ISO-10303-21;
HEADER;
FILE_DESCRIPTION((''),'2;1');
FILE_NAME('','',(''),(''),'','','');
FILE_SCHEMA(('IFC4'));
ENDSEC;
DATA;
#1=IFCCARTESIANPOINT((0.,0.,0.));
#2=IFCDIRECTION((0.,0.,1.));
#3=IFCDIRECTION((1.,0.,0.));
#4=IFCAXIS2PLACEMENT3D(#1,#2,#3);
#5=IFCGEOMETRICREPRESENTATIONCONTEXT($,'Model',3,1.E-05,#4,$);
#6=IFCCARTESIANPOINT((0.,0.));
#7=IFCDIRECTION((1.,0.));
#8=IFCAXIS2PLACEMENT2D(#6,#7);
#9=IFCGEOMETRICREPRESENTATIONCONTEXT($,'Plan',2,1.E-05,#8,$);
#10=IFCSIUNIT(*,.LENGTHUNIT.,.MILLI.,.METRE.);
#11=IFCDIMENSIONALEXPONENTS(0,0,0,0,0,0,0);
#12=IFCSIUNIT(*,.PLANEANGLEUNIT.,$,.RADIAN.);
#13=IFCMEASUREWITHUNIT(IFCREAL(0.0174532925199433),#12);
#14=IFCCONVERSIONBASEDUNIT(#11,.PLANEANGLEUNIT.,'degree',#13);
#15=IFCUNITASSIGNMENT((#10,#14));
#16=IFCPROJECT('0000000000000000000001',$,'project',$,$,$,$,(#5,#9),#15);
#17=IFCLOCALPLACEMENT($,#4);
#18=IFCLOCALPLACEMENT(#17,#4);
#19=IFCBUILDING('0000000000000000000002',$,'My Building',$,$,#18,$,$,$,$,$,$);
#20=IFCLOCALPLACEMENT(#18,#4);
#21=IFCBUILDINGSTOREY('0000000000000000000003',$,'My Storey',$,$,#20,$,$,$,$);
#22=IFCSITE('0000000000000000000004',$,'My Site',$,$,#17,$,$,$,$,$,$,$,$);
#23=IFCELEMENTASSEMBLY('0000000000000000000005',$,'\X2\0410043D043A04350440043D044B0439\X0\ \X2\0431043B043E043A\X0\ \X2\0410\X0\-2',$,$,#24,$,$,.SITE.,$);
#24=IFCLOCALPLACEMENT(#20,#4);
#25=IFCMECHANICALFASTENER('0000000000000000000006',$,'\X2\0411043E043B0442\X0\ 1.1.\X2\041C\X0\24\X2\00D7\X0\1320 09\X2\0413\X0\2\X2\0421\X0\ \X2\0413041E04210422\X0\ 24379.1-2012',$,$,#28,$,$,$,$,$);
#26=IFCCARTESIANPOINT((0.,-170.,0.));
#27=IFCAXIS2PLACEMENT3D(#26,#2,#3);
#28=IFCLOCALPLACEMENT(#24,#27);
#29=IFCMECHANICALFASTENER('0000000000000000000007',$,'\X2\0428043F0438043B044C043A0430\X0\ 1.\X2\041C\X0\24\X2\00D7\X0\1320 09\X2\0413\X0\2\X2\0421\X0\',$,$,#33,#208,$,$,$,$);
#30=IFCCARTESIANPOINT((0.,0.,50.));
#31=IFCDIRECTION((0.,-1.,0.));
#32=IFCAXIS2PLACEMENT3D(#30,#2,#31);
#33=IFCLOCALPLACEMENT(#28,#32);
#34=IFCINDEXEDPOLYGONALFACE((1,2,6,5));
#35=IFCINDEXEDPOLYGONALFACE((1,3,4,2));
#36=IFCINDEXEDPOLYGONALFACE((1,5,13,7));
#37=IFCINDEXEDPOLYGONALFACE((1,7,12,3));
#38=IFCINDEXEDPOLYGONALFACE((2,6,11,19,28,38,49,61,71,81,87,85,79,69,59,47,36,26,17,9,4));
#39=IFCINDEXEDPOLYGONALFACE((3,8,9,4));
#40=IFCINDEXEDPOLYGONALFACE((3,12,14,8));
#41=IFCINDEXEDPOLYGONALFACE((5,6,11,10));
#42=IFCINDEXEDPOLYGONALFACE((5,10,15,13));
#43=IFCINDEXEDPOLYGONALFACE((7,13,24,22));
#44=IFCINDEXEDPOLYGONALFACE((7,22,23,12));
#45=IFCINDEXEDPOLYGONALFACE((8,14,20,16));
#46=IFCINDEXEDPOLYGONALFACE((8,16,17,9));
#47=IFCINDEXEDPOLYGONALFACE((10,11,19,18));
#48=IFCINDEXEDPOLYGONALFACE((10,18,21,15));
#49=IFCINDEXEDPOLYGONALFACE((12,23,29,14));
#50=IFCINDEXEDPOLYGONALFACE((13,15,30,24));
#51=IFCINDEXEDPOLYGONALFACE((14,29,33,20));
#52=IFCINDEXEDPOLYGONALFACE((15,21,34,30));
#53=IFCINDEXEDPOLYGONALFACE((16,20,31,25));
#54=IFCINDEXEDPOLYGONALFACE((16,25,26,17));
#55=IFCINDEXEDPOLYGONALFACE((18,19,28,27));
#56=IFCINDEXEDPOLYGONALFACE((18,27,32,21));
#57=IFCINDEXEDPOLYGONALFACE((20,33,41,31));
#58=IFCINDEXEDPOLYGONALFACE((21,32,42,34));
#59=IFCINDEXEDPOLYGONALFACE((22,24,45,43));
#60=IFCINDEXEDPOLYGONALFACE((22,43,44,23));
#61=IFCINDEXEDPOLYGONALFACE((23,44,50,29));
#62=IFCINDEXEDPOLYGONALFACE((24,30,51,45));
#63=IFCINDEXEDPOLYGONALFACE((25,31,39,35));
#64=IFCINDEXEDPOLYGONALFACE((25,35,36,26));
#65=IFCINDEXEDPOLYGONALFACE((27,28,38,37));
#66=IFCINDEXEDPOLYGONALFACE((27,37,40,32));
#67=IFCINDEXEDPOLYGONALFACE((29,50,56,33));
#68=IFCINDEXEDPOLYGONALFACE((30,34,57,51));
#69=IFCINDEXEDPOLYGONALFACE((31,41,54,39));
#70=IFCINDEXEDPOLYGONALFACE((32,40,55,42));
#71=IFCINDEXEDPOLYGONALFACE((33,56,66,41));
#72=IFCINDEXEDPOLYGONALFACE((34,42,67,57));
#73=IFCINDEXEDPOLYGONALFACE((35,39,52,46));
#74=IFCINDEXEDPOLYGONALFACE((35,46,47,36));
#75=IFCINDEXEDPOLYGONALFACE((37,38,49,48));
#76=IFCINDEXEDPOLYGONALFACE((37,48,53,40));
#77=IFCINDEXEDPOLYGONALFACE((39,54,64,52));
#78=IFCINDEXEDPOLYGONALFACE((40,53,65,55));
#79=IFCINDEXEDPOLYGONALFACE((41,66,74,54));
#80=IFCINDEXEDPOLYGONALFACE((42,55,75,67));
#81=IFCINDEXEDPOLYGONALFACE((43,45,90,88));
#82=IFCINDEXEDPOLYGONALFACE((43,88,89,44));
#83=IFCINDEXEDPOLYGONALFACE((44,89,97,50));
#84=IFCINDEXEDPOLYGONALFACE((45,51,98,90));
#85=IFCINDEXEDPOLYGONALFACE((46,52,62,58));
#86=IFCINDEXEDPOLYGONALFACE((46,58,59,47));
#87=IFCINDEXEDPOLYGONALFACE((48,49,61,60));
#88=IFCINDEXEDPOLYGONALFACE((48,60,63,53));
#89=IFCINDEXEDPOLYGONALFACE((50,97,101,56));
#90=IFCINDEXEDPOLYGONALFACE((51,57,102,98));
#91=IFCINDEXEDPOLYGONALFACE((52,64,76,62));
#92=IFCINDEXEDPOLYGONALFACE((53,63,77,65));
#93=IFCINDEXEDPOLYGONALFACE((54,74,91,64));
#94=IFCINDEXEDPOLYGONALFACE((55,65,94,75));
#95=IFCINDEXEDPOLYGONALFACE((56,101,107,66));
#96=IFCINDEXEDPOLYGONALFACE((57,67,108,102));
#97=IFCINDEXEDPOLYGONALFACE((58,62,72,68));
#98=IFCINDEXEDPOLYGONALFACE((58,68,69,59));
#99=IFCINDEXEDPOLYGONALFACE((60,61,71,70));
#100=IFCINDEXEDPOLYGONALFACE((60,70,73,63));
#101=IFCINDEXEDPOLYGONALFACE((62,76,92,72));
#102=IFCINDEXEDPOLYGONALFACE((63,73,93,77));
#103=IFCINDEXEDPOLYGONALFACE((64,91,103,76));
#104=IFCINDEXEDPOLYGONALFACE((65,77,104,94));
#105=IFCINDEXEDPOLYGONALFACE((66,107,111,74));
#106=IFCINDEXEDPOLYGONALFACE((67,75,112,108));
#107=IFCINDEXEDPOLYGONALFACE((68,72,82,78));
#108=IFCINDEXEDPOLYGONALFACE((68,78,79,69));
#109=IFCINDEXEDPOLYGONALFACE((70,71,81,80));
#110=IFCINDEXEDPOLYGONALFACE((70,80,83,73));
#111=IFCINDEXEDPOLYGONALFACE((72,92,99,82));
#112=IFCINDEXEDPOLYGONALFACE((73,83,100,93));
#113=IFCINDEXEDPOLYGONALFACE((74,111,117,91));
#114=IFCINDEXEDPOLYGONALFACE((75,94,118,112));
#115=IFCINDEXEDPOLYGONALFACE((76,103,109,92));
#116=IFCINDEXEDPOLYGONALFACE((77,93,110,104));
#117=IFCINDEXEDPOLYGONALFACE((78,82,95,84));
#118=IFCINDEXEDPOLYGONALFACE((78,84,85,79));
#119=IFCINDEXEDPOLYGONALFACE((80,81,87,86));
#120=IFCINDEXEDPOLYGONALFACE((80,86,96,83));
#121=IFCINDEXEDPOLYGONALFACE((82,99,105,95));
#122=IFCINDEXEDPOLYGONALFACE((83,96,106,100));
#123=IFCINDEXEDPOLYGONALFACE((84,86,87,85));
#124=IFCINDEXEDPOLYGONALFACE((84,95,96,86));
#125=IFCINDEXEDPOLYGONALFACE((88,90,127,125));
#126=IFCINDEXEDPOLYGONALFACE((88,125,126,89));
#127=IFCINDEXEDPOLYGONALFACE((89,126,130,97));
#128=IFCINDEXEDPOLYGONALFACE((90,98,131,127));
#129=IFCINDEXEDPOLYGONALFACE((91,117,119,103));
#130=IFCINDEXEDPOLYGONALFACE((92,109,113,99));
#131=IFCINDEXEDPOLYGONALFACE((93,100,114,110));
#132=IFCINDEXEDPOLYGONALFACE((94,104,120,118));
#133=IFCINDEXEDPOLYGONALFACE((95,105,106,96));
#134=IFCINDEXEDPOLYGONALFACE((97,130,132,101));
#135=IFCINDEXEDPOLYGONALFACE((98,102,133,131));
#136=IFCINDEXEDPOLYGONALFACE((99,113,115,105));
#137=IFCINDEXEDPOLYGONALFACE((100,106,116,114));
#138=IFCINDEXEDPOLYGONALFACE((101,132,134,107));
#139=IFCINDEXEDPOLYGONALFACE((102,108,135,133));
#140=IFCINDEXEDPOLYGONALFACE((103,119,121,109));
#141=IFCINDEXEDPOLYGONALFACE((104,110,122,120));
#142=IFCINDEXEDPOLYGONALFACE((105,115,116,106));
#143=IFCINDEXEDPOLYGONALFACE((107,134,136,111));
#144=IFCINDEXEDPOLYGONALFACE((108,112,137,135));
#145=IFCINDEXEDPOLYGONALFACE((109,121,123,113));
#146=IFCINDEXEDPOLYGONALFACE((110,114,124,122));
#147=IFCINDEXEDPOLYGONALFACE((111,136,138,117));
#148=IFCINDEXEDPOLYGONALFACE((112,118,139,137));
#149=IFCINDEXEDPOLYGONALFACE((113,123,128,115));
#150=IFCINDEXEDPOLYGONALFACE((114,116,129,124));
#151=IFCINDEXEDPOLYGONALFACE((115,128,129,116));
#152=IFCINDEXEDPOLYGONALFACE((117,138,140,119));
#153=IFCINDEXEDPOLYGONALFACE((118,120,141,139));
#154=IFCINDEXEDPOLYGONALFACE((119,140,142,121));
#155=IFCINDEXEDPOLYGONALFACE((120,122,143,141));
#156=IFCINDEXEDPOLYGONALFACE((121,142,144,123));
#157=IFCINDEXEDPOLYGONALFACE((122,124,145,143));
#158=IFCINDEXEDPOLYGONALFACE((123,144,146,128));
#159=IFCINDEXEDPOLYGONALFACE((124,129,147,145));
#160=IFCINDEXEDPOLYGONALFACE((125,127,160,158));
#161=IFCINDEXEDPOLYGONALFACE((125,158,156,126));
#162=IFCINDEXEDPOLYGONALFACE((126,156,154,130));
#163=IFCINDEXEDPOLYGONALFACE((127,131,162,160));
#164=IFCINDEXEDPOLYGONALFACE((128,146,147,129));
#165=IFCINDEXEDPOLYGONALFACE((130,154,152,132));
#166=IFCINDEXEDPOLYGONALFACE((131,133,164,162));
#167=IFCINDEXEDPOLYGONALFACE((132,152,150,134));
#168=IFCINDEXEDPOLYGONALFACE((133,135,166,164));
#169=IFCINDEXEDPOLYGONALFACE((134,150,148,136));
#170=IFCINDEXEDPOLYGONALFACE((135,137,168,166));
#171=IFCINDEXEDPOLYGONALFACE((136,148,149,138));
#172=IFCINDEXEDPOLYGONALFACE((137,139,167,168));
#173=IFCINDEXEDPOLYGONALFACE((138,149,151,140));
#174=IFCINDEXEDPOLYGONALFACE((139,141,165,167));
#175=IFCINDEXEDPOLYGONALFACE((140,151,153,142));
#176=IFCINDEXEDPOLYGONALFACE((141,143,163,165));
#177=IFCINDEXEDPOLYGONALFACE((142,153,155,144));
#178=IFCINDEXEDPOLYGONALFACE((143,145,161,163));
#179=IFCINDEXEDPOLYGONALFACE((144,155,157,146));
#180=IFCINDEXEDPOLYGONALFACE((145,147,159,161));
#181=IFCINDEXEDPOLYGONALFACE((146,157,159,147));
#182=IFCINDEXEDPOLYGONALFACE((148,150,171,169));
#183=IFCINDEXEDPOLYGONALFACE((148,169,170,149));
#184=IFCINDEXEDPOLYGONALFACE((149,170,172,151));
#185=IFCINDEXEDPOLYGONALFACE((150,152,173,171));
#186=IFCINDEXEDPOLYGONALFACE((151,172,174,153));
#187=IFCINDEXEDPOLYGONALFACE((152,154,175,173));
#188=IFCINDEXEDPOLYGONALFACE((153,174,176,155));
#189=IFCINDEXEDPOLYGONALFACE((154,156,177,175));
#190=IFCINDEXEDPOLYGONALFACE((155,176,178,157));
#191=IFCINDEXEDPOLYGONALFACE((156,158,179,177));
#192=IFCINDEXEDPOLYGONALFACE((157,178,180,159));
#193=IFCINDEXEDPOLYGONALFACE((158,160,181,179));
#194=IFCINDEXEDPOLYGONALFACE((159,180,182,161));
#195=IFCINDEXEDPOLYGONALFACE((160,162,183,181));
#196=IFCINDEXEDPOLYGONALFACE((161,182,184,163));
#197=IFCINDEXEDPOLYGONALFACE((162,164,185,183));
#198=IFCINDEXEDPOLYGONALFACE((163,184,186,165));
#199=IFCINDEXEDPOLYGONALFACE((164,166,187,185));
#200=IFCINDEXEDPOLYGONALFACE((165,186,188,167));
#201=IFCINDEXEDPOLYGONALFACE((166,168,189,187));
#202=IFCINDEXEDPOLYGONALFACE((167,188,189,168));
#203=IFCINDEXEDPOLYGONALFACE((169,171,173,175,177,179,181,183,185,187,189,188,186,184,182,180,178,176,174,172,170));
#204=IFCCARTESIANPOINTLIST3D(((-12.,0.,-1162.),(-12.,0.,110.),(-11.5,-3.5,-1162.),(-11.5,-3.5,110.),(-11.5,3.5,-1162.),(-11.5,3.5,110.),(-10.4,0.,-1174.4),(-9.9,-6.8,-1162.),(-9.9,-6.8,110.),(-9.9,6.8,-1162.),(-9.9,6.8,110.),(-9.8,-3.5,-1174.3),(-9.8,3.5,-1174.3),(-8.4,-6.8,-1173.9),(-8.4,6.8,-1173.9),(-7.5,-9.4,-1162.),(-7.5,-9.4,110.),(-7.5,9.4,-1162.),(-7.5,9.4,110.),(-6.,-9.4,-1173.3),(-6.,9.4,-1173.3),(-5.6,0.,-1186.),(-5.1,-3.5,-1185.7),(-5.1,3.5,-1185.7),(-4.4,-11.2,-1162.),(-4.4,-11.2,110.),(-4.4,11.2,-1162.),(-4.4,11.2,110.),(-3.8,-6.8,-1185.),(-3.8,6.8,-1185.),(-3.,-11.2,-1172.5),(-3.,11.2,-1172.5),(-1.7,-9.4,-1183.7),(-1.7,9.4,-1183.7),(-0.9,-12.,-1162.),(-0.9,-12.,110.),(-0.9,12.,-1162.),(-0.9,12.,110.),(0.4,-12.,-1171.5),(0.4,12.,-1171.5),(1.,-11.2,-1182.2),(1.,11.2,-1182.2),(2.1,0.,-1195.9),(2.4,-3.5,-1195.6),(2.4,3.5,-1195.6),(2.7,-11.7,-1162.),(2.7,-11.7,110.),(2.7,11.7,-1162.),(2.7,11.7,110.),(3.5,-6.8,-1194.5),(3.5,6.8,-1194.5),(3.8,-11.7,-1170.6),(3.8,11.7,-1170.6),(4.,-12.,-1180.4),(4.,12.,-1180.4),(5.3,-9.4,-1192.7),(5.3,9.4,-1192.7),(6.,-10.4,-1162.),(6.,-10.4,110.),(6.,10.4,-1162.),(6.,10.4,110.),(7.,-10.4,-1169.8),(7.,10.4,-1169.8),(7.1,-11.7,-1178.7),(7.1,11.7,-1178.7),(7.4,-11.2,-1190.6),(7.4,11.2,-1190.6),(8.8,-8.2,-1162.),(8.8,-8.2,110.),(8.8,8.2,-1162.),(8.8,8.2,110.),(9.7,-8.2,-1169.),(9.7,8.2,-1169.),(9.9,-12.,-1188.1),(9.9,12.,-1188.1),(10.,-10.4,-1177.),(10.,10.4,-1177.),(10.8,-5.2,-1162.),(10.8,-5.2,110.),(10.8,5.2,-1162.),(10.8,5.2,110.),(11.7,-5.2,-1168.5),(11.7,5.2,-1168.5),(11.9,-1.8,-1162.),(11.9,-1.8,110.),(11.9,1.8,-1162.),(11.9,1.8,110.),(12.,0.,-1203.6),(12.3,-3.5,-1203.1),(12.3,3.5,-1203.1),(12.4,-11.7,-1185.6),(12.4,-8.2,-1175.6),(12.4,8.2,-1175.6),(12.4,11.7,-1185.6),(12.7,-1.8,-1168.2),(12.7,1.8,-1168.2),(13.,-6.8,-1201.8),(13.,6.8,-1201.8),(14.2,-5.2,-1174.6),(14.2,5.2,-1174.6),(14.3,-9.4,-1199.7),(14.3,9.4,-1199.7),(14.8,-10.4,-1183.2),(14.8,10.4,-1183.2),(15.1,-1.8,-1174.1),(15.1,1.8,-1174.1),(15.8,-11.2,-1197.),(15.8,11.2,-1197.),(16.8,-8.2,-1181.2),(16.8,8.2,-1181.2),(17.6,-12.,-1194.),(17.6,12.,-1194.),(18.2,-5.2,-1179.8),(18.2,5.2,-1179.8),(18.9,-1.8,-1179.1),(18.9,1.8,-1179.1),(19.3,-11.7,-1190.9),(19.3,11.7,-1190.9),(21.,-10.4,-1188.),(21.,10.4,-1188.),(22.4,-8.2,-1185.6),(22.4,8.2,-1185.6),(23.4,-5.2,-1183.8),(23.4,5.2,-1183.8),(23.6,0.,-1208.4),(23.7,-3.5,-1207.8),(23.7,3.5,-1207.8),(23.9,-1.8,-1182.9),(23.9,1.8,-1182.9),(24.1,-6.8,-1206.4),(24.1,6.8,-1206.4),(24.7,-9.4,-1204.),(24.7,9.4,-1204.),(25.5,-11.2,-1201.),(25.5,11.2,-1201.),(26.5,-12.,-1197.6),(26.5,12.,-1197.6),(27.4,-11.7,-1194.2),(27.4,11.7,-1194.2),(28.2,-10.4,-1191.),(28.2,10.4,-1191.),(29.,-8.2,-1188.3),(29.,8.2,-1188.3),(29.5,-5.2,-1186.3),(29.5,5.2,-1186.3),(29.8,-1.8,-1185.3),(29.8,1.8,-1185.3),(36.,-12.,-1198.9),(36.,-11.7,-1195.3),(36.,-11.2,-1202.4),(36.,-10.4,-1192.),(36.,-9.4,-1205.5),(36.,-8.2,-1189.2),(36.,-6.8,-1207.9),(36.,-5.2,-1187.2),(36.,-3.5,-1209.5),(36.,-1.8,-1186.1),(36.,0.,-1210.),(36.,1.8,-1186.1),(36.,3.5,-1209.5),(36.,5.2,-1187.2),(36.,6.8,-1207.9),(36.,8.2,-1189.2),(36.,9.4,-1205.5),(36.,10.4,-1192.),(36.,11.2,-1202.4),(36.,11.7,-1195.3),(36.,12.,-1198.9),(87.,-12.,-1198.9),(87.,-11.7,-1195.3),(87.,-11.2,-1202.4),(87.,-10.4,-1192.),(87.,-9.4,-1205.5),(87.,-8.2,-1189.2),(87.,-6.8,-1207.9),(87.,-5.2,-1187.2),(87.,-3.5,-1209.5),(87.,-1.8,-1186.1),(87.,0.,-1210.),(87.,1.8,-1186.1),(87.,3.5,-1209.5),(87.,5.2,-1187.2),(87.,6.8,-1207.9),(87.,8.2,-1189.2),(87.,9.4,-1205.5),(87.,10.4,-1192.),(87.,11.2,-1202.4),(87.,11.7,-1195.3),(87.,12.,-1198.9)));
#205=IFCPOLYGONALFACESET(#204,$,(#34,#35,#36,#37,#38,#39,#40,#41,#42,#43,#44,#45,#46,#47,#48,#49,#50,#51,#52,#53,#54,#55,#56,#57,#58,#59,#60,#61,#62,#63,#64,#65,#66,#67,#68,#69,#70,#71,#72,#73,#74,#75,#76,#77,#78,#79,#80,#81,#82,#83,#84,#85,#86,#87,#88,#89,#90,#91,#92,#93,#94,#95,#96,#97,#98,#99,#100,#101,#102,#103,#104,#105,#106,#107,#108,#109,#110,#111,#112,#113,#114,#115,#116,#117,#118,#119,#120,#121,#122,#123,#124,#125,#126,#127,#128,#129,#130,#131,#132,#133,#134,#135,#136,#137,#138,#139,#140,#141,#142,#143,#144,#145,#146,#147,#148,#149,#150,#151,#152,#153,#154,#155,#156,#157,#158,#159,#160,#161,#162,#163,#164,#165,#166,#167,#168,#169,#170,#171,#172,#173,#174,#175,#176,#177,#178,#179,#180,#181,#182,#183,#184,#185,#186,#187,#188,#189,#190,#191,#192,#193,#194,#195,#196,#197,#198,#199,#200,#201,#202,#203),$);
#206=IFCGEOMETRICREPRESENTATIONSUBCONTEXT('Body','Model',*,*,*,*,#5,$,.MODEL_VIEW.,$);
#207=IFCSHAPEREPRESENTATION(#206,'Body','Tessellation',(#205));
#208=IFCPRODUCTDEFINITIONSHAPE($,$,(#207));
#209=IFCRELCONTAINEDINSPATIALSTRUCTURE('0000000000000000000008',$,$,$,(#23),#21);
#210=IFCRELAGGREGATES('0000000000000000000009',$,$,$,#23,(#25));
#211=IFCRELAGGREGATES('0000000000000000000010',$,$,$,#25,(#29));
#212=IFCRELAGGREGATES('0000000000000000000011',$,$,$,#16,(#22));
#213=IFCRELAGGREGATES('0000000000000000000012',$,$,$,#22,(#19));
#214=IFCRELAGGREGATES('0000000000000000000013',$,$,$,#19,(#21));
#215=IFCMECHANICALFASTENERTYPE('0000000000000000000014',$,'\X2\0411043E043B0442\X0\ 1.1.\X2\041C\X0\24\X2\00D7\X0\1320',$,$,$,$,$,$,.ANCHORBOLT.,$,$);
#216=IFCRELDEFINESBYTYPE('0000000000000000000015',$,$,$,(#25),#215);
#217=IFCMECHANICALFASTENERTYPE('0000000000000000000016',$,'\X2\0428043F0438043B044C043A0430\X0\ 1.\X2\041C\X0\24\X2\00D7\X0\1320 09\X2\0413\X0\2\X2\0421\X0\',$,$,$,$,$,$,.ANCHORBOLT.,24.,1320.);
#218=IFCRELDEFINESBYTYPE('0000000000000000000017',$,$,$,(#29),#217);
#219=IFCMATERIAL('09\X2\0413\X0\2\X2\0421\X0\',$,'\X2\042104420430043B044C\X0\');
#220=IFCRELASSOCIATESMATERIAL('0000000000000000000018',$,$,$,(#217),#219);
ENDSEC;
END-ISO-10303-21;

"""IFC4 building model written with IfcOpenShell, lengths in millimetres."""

from ifc_helpers import new_model, entity, si_unit, converted_unit, frame, origin_with_axes, origin_2d_with_axis, place, context, subcontext, project, spatial, source, transform, mapped, material, type_object, type_shapes, element, aggregate, save


model = new_model("IFC4")

# Units and contexts
model_context = context("Model", 3, precision=1e-05, world=origin_with_axes())
plan_context = context("Plan", 2, precision=1e-05, world=origin_2d_with_axis())
body_context = subcontext(model_context, "Body", "Model", "MODEL_VIEW")
ifc_project = project(units=[si_unit("LENGTHUNIT", "METRE", prefix="MILLI"), converted_unit("PLANEANGLEUNIT", "degree", entity("IfcReal", 0.0174532925199433), si_unit("PLANEANGLEUNIT", "RADIAN"), dimensions=[0, 0, 0, 0, 0, 0, 0])], contexts=[model_context, plan_context])

# Site, building, storey
site_placement = place(None, origin_with_axes())
site = spatial("IfcSite", under=ifc_project, at=site_placement, Name="My Site")
building_placement = place(site_placement, origin_with_axes())
building = spatial("IfcBuilding", under=site, at=building_placement, Name="My Building")
storey_placement = place(building_placement, origin_with_axes())
storey = spatial("IfcBuildingStorey", under=building, at=storey_placement, Name="My Storey")

# Shared definitions
placement = place(storey_placement, origin_with_axes())

# Element assembly, mechanical fasteners
assembly_1 = element("IfcElementAssembly", 1, at=placement, inside=storey, Name="Анкерный блок А-2", AssemblyPlace="SITE")
mechanical_fastener_type_1 = type_object("IfcMechanicalFastenerType", Name="Болт 1.1.М24×1320", PredefinedType="ANCHORBOLT")
mechanical_fastener_1_placement = place(placement, frame((0.0, -170.0, 0.0), z_axis=(0.0, 0.0, 1.0), x_axis=(1.0, 0.0, 0.0)))
mechanical_fastener_1 = element("IfcMechanicalFastener", 2, at=mechanical_fastener_1_placement, type_object=mechanical_fastener_type_1, Name="Болт 1.1.М24×1320 09Г2С ГОСТ 24379.1-2012")
ifc_material_1 = material(Name="09Г2С", Category="Сталь")
mechanical_fastener_type_2 = type_object("IfcMechanicalFastenerType", Name="Шпилька 1.М24×1320 09Г2С", NominalDiameter=24.0, NominalLength=1320.0, PredefinedType="ANCHORBOLT", material=ifc_material_1)
shared_shape_1 = source(frame((0.0, 0.0, 110.0), z_axis=(0.0, 0.0, 1.0), x_axis=(1.0, 0.0, 0.0)), body_context, "Body", "AdvancedSweptSolid", [
    entity("IfcSweptDiskSolid", entity("IfcIndexedPolyCurve", entity("IfcCartesianPointList3D", [[0.0, 0.0, 0.0], [0.0, 0.0, -1272.0], [10.5, 0.0, -1297.5], [36.0, 0.0, -1308.0], [87.0, 0.0, -1308.0]]), [entity("IfcLineIndex", [1, 2]), entity("IfcArcIndex", [2, 3, 4]), entity("IfcLineIndex", [4, 5])]), 12.0),
])
type_shapes(mechanical_fastener_type_2, [shared_shape_1])
mechanical_fastener_2_placement = place(mechanical_fastener_1_placement, frame((0.0, 0.0, 50.0), z_axis=(0.0, 0.0, 1.0), x_axis=(0.0, -1.0, 0.0)))
mechanical_fastener_2 = element("IfcMechanicalFastener", 3, at=mechanical_fastener_2_placement, type_object=mechanical_fastener_type_2, Name="Шпилька 1.М24×1320 09Г2С", context=body_context, shape_type="MappedRepresentation", body=[
    mapped(shared_shape_1, transform((0.0, 0.0, 0.0), x_axis=(1.0, 0.0, 0.0), y_axis=(0.0, 1.0, 0.0), z_axis=(0.0, 0.0, 1.0), scale=1.0)),
])
aggregate(assembly_1, [mechanical_fastener_1])

aggregate(mechanical_fastener_1, [mechanical_fastener_2])

save(model, "model.ifc")
